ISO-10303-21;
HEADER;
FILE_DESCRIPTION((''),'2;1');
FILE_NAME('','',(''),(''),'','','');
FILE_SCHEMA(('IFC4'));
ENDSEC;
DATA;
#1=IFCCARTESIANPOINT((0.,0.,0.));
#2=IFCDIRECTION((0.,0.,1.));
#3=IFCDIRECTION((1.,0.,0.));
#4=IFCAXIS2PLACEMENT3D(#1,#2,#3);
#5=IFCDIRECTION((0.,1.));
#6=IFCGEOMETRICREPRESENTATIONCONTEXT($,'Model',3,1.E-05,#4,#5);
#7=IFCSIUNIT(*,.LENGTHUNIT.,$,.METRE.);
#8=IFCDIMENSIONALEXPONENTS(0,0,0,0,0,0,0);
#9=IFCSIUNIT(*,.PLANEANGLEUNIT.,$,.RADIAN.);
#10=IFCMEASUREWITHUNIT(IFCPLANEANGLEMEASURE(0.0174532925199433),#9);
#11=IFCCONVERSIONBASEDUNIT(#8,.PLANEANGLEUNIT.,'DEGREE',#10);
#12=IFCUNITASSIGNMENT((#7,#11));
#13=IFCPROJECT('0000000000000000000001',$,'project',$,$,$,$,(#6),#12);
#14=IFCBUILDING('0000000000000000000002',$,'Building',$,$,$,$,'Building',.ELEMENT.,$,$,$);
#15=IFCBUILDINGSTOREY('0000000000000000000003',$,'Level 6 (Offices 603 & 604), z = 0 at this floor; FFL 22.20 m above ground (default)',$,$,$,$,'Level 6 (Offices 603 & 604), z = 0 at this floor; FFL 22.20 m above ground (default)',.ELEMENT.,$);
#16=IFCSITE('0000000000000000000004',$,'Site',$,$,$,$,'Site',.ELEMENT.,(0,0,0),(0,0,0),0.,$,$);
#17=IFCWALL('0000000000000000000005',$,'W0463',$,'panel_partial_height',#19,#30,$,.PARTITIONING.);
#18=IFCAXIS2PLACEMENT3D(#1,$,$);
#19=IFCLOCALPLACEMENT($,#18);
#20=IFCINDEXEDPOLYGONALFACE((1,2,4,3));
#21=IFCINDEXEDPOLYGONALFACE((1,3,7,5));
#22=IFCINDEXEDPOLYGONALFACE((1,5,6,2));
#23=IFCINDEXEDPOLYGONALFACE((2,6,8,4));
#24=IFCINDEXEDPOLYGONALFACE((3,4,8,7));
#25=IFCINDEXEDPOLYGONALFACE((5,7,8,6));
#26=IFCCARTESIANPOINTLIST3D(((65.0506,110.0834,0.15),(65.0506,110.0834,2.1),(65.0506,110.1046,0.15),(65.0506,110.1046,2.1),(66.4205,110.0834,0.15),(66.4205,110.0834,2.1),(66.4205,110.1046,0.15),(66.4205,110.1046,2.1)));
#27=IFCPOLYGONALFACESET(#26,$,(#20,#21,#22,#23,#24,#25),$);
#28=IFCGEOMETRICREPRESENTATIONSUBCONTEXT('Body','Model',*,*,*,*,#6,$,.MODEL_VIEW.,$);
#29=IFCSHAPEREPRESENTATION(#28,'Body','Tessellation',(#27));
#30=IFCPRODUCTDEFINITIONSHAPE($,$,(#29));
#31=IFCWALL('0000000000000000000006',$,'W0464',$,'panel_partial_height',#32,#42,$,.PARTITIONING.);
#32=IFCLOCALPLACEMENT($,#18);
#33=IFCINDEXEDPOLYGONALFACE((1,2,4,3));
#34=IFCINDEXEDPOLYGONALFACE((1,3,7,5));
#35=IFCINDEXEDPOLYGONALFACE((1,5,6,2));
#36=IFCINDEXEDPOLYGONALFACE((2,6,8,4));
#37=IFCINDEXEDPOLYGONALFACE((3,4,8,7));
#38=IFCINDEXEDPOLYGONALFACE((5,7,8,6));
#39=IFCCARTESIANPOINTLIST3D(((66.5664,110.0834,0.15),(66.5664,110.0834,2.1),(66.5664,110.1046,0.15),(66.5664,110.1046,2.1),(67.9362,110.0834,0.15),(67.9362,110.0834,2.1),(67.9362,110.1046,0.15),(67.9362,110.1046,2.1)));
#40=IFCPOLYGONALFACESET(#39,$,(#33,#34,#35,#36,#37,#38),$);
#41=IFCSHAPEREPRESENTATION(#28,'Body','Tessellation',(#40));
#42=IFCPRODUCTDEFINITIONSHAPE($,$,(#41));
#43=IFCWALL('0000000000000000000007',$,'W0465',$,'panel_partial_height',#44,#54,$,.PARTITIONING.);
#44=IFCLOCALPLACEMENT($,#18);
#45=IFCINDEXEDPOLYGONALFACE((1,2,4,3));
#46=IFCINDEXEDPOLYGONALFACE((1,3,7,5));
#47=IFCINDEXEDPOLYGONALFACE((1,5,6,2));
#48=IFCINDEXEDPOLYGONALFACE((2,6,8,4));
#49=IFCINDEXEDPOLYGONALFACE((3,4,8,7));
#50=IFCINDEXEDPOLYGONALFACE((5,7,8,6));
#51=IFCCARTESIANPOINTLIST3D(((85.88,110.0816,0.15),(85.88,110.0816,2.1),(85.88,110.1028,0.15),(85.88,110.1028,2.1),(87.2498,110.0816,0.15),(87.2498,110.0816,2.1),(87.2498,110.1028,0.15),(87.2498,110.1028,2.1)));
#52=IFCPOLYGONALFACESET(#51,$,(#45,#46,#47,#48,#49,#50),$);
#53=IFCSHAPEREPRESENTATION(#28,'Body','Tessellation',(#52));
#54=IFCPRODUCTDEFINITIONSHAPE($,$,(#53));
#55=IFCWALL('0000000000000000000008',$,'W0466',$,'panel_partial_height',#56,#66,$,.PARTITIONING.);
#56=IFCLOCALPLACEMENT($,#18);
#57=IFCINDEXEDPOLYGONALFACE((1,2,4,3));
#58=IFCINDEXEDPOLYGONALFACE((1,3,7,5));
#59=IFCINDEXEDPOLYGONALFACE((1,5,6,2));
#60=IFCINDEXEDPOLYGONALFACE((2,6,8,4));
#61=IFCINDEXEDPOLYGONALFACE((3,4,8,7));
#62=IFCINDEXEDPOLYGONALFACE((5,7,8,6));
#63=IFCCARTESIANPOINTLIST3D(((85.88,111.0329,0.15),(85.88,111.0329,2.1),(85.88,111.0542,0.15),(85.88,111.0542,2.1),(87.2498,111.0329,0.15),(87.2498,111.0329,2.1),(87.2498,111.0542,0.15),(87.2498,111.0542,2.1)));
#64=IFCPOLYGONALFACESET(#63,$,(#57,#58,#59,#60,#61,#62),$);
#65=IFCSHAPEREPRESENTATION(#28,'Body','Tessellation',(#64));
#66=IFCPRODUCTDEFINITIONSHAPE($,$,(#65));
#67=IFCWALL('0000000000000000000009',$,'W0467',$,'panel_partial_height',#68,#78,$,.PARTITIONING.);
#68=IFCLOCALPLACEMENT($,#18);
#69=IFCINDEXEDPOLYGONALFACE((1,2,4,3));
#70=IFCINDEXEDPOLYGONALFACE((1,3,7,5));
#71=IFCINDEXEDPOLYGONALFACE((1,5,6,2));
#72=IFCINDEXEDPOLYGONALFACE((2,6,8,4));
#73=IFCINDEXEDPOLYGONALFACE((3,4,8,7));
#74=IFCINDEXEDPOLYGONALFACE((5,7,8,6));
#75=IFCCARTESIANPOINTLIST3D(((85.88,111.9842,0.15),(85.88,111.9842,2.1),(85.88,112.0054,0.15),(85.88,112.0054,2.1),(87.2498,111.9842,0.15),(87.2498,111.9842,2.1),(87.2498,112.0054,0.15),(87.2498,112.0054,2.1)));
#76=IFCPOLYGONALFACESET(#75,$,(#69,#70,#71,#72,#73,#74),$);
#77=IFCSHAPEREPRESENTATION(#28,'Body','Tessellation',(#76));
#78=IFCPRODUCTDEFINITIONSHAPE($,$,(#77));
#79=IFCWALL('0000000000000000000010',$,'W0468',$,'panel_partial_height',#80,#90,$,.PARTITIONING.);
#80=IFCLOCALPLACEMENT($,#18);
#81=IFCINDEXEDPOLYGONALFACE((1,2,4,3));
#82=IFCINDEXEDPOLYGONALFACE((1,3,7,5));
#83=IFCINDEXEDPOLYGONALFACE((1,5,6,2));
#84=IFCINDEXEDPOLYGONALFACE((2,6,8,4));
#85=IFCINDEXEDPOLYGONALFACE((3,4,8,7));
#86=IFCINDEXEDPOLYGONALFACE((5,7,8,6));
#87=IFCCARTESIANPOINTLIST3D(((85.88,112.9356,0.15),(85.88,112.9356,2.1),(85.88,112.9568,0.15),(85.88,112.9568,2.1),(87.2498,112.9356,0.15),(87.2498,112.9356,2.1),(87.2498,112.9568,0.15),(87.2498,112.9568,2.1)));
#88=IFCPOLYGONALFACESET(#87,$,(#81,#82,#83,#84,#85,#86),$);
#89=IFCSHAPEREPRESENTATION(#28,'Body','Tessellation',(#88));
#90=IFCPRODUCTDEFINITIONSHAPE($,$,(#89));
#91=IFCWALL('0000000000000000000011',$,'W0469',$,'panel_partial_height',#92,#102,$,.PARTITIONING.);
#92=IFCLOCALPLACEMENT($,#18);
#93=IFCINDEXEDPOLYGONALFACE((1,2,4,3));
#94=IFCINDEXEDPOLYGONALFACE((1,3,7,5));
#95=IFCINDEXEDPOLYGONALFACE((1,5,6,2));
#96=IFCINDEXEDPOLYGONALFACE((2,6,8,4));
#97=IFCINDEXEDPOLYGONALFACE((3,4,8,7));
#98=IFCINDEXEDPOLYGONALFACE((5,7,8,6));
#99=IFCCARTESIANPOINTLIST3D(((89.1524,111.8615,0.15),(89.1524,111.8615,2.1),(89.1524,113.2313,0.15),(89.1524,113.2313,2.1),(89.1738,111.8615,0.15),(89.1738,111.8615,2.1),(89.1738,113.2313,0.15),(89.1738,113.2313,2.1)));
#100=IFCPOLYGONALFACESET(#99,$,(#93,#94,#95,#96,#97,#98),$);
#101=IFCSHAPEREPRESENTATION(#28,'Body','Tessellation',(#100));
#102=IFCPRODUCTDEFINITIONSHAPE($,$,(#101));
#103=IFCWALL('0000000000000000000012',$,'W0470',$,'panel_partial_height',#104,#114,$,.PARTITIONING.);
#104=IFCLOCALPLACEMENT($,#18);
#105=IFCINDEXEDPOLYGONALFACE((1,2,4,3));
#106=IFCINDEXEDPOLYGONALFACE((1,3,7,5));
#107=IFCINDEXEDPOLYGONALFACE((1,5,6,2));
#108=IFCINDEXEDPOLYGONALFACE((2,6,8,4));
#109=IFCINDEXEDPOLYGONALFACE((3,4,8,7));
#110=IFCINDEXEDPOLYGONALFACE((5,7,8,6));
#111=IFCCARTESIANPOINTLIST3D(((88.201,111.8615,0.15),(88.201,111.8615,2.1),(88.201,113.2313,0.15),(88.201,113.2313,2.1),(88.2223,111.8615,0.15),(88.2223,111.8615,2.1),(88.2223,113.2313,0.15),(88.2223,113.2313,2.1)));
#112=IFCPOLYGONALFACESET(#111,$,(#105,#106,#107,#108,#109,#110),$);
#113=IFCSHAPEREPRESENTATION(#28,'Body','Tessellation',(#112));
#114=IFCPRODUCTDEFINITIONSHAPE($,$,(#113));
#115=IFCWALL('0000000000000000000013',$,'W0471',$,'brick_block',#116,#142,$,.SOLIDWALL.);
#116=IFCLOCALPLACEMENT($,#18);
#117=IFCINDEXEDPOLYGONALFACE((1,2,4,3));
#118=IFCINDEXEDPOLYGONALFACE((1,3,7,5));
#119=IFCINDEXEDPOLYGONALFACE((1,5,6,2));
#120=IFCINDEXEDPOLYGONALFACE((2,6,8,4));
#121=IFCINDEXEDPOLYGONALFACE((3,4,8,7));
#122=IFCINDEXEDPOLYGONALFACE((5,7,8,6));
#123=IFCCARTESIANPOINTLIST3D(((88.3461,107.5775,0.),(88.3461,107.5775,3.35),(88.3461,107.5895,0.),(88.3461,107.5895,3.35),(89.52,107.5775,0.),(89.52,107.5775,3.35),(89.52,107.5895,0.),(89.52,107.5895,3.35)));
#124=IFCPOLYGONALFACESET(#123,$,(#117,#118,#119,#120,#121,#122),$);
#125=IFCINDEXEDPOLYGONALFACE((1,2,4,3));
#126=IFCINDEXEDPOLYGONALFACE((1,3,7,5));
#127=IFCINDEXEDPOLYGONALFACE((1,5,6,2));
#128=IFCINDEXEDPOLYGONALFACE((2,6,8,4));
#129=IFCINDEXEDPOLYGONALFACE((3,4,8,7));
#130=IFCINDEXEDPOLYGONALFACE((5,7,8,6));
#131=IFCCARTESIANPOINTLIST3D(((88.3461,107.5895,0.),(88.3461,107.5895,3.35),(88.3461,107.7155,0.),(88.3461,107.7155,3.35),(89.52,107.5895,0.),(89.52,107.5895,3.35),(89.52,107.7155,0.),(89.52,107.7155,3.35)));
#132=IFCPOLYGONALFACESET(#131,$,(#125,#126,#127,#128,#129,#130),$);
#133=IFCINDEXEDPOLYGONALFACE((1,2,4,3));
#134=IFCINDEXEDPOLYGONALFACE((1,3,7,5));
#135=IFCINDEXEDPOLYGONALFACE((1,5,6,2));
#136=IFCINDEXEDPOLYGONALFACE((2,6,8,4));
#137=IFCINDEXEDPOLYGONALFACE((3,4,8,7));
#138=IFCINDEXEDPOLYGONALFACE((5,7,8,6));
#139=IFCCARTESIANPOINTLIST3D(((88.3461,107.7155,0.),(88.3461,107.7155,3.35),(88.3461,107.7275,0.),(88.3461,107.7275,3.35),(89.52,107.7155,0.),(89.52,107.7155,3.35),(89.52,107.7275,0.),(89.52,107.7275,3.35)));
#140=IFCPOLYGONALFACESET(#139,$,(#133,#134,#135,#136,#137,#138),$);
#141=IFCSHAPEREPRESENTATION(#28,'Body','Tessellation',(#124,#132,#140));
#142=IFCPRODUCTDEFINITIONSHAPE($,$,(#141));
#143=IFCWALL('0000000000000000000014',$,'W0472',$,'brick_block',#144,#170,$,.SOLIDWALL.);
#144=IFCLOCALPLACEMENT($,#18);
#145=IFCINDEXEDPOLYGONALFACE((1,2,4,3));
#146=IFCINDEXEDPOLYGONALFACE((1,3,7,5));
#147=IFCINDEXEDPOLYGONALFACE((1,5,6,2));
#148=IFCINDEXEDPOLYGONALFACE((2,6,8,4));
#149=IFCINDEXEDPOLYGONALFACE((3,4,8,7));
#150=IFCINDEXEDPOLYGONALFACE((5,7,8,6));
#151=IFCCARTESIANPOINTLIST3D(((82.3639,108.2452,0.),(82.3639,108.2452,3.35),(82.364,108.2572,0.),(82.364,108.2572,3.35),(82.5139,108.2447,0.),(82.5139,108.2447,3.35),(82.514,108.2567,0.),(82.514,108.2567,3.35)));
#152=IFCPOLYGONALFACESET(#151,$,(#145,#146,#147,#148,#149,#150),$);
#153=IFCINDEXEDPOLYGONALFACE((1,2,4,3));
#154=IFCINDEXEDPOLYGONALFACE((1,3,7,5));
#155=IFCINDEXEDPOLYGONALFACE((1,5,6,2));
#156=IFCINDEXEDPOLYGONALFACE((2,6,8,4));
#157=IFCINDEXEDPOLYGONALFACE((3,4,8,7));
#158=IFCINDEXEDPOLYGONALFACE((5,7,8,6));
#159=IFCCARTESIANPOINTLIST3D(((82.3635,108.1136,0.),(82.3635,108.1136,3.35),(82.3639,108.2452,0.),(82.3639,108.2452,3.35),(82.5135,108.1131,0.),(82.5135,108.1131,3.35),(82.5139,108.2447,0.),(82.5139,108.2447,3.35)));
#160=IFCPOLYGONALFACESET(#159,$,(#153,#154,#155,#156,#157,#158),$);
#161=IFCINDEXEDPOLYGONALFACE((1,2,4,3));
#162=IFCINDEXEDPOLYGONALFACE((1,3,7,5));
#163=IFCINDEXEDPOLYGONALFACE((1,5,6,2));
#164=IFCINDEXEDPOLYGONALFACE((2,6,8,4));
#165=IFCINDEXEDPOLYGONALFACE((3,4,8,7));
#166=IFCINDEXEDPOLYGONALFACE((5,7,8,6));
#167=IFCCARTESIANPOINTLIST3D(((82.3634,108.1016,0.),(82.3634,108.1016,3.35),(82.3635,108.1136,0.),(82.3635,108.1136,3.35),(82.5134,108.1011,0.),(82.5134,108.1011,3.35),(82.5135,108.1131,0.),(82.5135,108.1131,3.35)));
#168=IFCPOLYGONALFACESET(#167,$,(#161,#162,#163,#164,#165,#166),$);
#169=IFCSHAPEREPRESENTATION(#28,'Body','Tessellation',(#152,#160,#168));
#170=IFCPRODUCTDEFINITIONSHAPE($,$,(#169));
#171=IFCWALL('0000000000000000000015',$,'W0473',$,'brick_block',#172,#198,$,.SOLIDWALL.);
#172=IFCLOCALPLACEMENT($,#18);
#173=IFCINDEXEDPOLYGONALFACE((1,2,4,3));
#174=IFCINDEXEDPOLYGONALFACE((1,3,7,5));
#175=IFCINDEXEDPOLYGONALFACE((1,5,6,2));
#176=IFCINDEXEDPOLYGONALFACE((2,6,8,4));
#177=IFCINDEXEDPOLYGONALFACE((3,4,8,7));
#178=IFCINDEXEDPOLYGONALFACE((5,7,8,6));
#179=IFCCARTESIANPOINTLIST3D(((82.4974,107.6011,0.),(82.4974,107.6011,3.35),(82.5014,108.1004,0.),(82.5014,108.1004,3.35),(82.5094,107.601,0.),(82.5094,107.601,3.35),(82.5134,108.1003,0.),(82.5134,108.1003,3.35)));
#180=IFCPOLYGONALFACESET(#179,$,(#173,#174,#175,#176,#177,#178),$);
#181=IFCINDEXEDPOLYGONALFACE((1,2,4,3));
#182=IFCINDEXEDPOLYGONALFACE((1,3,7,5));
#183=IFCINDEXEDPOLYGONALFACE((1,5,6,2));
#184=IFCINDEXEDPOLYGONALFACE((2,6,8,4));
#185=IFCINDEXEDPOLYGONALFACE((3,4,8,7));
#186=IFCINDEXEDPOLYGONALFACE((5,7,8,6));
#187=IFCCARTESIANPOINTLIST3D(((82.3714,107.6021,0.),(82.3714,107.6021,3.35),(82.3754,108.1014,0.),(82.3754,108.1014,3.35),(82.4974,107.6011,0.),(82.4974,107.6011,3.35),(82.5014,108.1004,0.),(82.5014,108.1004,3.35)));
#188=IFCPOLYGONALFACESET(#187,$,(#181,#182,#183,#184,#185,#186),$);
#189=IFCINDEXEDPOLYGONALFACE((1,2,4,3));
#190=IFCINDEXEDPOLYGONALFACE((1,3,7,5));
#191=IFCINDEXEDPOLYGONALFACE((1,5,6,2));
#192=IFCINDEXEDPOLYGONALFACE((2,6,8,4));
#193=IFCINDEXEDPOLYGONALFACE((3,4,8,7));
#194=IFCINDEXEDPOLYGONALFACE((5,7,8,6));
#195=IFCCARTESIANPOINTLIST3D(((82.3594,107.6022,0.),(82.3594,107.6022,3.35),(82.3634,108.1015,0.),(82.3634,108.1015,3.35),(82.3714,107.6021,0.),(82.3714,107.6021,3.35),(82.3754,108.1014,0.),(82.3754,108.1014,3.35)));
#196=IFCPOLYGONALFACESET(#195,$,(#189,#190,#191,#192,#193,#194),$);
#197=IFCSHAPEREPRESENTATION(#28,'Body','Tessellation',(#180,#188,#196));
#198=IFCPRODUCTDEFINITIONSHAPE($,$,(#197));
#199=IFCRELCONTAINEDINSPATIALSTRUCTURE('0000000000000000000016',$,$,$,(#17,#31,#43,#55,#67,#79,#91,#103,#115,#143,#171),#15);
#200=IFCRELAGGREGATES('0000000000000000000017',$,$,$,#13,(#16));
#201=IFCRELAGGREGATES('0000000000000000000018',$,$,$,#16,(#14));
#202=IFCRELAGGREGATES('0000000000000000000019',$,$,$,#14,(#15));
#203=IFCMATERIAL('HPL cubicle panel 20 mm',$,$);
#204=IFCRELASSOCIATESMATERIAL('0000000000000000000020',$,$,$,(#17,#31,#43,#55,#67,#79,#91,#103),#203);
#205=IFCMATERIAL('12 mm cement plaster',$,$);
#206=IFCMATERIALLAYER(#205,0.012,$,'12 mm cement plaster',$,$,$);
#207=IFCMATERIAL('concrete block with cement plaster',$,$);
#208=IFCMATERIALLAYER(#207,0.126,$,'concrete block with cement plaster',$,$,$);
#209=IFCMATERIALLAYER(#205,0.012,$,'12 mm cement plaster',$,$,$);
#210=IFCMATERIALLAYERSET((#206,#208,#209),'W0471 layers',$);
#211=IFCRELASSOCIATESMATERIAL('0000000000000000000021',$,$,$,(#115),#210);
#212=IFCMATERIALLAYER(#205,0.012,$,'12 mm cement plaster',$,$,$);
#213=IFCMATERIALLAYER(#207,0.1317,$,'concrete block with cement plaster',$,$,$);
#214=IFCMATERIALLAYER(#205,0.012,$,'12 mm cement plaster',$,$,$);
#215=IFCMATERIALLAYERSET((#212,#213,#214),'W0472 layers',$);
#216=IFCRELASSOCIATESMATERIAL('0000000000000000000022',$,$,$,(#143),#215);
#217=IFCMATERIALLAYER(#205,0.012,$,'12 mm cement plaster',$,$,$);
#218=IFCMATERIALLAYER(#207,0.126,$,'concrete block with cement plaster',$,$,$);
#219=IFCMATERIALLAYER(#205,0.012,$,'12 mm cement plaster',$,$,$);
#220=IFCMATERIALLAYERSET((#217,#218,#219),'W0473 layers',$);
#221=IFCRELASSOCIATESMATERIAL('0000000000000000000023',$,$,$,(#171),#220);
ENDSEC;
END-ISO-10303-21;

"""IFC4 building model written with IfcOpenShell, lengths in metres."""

from ifc_helpers import new_model, entity, si_unit, converted_unit, direction, frame, frame_2d, origin_with_axes, origin_2d_with_axis, place, context, subcontext, project, spatial, rectangle, extrude, material, layer, layer_set, layer_usage, element, save


model = new_model("IFC4")

# Units and contexts
model_context = context("Model", 3, precision=1e-05, world=origin_with_axes(), true_north=direction((0.0, 1.0)))
body_context = subcontext(model_context, "Body", "Model", "MODEL_VIEW")
ifc_project = project(units=[si_unit("LENGTHUNIT", "METRE"), converted_unit("PLANEANGLEUNIT", "DEGREE", entity("IfcPlaneAngleMeasure", 0.0174532925199433), si_unit("PLANEANGLEUNIT", "RADIAN"), dimensions=[0, 0, 0, 0, 0, 0, 0])], contexts=[model_context])

# Site, building, storey
site = spatial("IfcSite", under=ifc_project, Name="Site", LongName="Site", CompositionType="ELEMENT", RefLatitude=(0, 0, 0), RefLongitude=(0, 0, 0), RefElevation=0.0)
building = spatial("IfcBuilding", under=site, Name="Building", LongName="Building", CompositionType="ELEMENT")
storey = spatial("IfcBuildingStorey", under=building, Name="Level 6 (Offices 603 & 604), z = 0 at this floor; FFL 22.20 m above ground (default)", LongName="Level 6 (Offices 603 & 604), z = 0 at this floor; FFL 22.20 m above ground (default)", CompositionType="ELEMENT")

# Walls
placement = place(None, origin_with_axes())
ifc_material_1 = material(Name="HPL cubicle panel 20 mm")
element("IfcWall", 1, at=placement, inside=storey, material=ifc_material_1, Name="W0463", ObjectType="panel_partial_height", PredefinedType="PARTITIONING", context=body_context, shape_type="SweptSolid", body=[
    extrude(rectangle(XDim=1.3699, YDim=0.0213, at=origin_2d_with_axis()), frame((65.7356, 110.094, 0.15), z_axis=(0.0, 0.0, 1.0), x_axis=(1.0, 0.0, 0.0)), (0.0, 0.0, 1.0), 1.95),
])
element("IfcWall", 2, at=placement, inside=storey, material=ifc_material_1, Name="W0464", ObjectType="panel_partial_height", PredefinedType="PARTITIONING", context=body_context, shape_type="SweptSolid", body=[
    extrude(rectangle(XDim=1.3698, YDim=0.0213, at=frame_2d((0.0, 0.0), x_axis=(1.0, 0.0))), frame((67.2513, 110.094, 0.15), z_axis=(0.0, 0.0, 1.0), x_axis=(1.0, 0.0, 0.0)), (0.0, 0.0, 1.0), 1.95),
])
element("IfcWall", 3, at=placement, inside=storey, material=ifc_material_1, Name="W0465", ObjectType="panel_partial_height", PredefinedType="PARTITIONING", context=body_context, shape_type="SweptSolid", body=[
    extrude(rectangle(XDim=1.3698, YDim=0.0213, at=frame_2d((0.0, 0.0), x_axis=(1.0, 0.0))), frame((86.5649, 110.0922, 0.15), z_axis=(0.0, 0.0, 1.0), x_axis=(1.0, 0.0, 0.0)), (0.0, 0.0, 1.0), 1.95),
])
element("IfcWall", 4, at=placement, inside=storey, material=ifc_material_1, Name="W0466", ObjectType="panel_partial_height", PredefinedType="PARTITIONING", context=body_context, shape_type="SweptSolid", body=[
    extrude(rectangle(XDim=1.3698, YDim=0.0213, at=frame_2d((0.0, 0.0), x_axis=(1.0, 0.0))), frame((86.5649, 111.0435, 0.15), z_axis=(0.0, 0.0, 1.0), x_axis=(1.0, 0.0, 0.0)), (0.0, 0.0, 1.0), 1.95),
])
element("IfcWall", 5, at=placement, inside=storey, material=ifc_material_1, Name="W0467", ObjectType="panel_partial_height", PredefinedType="PARTITIONING", context=body_context, shape_type="SweptSolid", body=[
    extrude(rectangle(XDim=1.3698, YDim=0.0213, at=frame_2d((0.0, 0.0), x_axis=(1.0, 0.0))), frame((86.5649, 111.9948, 0.15), z_axis=(0.0, 0.0, 1.0), x_axis=(1.0, 0.0, 0.0)), (0.0, 0.0, 1.0), 1.95),
])
element("IfcWall", 6, at=placement, inside=storey, material=ifc_material_1, Name="W0468", ObjectType="panel_partial_height", PredefinedType="PARTITIONING", context=body_context, shape_type="SweptSolid", body=[
    extrude(rectangle(XDim=1.3698, YDim=0.0213, at=frame_2d((0.0, 0.0), x_axis=(1.0, 0.0))), frame((86.5649, 112.9462, 0.15), z_axis=(0.0, 0.0, 1.0), x_axis=(1.0, 0.0, 0.0)), (0.0, 0.0, 1.0), 1.95),
])
element("IfcWall", 7, at=placement, inside=storey, material=ifc_material_1, Name="W0469", ObjectType="panel_partial_height", PredefinedType="PARTITIONING", context=body_context, shape_type="SweptSolid", body=[
    extrude(rectangle(XDim=1.3698, YDim=0.0213, at=frame_2d((0.0, 0.0), x_axis=(0.0, 1.0))), frame((89.1631, 112.5464, 0.15), z_axis=(0.0, 0.0, 1.0), x_axis=(1.0, 0.0, 0.0)), (0.0, 0.0, 1.0), 1.95),
])
element("IfcWall", 8, at=placement, inside=storey, material=ifc_material_1, Name="W0470", ObjectType="panel_partial_height", PredefinedType="PARTITIONING", context=body_context, shape_type="SweptSolid", body=[
    extrude(rectangle(XDim=1.3698, YDim=0.0213, at=frame_2d((0.0, 0.0), x_axis=(0.0, 1.0))), frame((88.2117, 112.5464, 0.15), z_axis=(0.0, 0.0, 1.0), x_axis=(1.0, 0.0, 0.0)), (0.0, 0.0, 1.0), 1.95),
])
ifc_material_2 = material(Name="12 mm cement plaster")
ifc_layer_1 = layer(ifc_material_2, 0.012, Name="12 mm cement plaster")
ifc_material_3 = material(Name="concrete block with cement plaster")
ifc_layer_2 = layer(ifc_material_3, 0.126, Name="concrete block with cement plaster")
ifc_layer_3 = layer(ifc_material_2, 0.012, Name="12 mm cement plaster")
ifc_layer_set_1 = layer_set([ifc_layer_1, ifc_layer_2, ifc_layer_3], Name="W0471 layers")
ifc_layer_usage_1 = layer_usage(ifc_layer_set_1, "AXIS2", "POSITIVE", -0.075)
element("IfcWall", 9, at=placement, inside=storey, material=ifc_layer_usage_1, Name="W0471", ObjectType="brick_block", PredefinedType="SOLIDWALL", context=body_context, shape_type="SweptSolid", body=[
    extrude(rectangle(XDim=1.1739, YDim=0.012, at=frame_2d((0.0, 0.0), x_axis=(1.0, 0.0))), frame((88.933, 107.5835, 0.0), z_axis=(0.0, 0.0, 1.0), x_axis=(1.0, 0.0, 0.0)), (0.0, 0.0, 1.0), 3.35),
    extrude(rectangle(XDim=1.1739, YDim=0.126, at=frame_2d((0.0, 0.069), x_axis=(1.0, 0.0))), frame((88.933, 107.5835, 0.0), z_axis=(0.0, 0.0, 1.0), x_axis=(1.0, 0.0, 0.0)), (0.0, 0.0, 1.0), 3.35),
    extrude(rectangle(XDim=1.1739, YDim=0.012, at=frame_2d((0.0, 0.138), x_axis=(1.0, 0.0))), frame((88.933, 107.5835, 0.0), z_axis=(0.0, 0.0, 1.0), x_axis=(1.0, 0.0, 0.0)), (0.0, 0.0, 1.0), 3.35),
])
ifc_layer_4 = layer(ifc_material_2, 0.012, Name="12 mm cement plaster")
ifc_layer_5 = layer(ifc_material_3, 0.1317, Name="concrete block with cement plaster")
ifc_layer_6 = layer(ifc_material_2, 0.012, Name="12 mm cement plaster")
ifc_layer_set_2 = layer_set([ifc_layer_4, ifc_layer_5, ifc_layer_6], Name="W0472 layers")
ifc_layer_usage_2 = layer_usage(ifc_layer_set_2, "AXIS2", "POSITIVE", -0.0779)
element("IfcWall", 10, at=placement, inside=storey, material=ifc_layer_usage_2, Name="W0472", ObjectType="brick_block", PredefinedType="SOLIDWALL", context=body_context, shape_type="SweptSolid", body=[
    extrude(rectangle(XDim=0.15, YDim=0.012, at=frame_2d((0.0, 0.0), x_axis=(0.999994, -0.003333))), frame((82.4389, 108.251, 0.0), z_axis=(0.0, 0.0, 1.0), x_axis=(1.0, 0.0, 0.0)), (0.0, 0.0, 1.0), 3.35),
    extrude(rectangle(XDim=0.15, YDim=0.1317, at=frame_2d((-0.0002, -0.0718), x_axis=(0.999994, -0.003333))), frame((82.4389, 108.251, 0.0), z_axis=(0.0, 0.0, 1.0), x_axis=(1.0, 0.0, 0.0)), (0.0, 0.0, 1.0), 3.35),
    extrude(rectangle(XDim=0.15, YDim=0.012, at=frame_2d((-0.0005, -0.1437), x_axis=(0.999994, -0.003333))), frame((82.4389, 108.251, 0.0), z_axis=(0.0, 0.0, 1.0), x_axis=(1.0, 0.0, 0.0)), (0.0, 0.0, 1.0), 3.35),
])
ifc_layer_7 = layer(ifc_material_2, 0.012, Name="12 mm cement plaster")
ifc_layer_8 = layer(ifc_material_3, 0.126, Name="concrete block with cement plaster")
ifc_layer_9 = layer(ifc_material_2, 0.012, Name="12 mm cement plaster")
ifc_layer_set_3 = layer_set([ifc_layer_7, ifc_layer_8, ifc_layer_9], Name="W0473 layers")
ifc_layer_usage_3 = layer_usage(ifc_layer_set_3, "AXIS2", "POSITIVE", -0.075)
element("IfcWall", 11, at=placement, inside=storey, material=ifc_layer_usage_3, Name="W0473", ObjectType="brick_block", PredefinedType="SOLIDWALL", context=body_context, shape_type="SweptSolid", body=[
    extrude(rectangle(XDim=0.4993, YDim=0.012, at=frame_2d((0.0, 0.0), x_axis=(0.008011, 0.999968))), frame((82.5054, 107.8507, 0.0), z_axis=(0.0, 0.0, 1.0), x_axis=(1.0, 0.0, 0.0)), (0.0, 0.0, 1.0), 3.35),
    extrude(rectangle(XDim=0.4993, YDim=0.126, at=frame_2d((-0.069, 0.0006), x_axis=(0.008011, 0.999968))), frame((82.5054, 107.8507, 0.0), z_axis=(0.0, 0.0, 1.0), x_axis=(1.0, 0.0, 0.0)), (0.0, 0.0, 1.0), 3.35),
    extrude(rectangle(XDim=0.4993, YDim=0.012, at=frame_2d((-0.138, 0.0011), x_axis=(0.008011, 0.999968))), frame((82.5054, 107.8507, 0.0), z_axis=(0.0, 0.0, 1.0), x_axis=(1.0, 0.0, 0.0)), (0.0, 0.0, 1.0), 3.35),
])

save(model, "model.ifc")
